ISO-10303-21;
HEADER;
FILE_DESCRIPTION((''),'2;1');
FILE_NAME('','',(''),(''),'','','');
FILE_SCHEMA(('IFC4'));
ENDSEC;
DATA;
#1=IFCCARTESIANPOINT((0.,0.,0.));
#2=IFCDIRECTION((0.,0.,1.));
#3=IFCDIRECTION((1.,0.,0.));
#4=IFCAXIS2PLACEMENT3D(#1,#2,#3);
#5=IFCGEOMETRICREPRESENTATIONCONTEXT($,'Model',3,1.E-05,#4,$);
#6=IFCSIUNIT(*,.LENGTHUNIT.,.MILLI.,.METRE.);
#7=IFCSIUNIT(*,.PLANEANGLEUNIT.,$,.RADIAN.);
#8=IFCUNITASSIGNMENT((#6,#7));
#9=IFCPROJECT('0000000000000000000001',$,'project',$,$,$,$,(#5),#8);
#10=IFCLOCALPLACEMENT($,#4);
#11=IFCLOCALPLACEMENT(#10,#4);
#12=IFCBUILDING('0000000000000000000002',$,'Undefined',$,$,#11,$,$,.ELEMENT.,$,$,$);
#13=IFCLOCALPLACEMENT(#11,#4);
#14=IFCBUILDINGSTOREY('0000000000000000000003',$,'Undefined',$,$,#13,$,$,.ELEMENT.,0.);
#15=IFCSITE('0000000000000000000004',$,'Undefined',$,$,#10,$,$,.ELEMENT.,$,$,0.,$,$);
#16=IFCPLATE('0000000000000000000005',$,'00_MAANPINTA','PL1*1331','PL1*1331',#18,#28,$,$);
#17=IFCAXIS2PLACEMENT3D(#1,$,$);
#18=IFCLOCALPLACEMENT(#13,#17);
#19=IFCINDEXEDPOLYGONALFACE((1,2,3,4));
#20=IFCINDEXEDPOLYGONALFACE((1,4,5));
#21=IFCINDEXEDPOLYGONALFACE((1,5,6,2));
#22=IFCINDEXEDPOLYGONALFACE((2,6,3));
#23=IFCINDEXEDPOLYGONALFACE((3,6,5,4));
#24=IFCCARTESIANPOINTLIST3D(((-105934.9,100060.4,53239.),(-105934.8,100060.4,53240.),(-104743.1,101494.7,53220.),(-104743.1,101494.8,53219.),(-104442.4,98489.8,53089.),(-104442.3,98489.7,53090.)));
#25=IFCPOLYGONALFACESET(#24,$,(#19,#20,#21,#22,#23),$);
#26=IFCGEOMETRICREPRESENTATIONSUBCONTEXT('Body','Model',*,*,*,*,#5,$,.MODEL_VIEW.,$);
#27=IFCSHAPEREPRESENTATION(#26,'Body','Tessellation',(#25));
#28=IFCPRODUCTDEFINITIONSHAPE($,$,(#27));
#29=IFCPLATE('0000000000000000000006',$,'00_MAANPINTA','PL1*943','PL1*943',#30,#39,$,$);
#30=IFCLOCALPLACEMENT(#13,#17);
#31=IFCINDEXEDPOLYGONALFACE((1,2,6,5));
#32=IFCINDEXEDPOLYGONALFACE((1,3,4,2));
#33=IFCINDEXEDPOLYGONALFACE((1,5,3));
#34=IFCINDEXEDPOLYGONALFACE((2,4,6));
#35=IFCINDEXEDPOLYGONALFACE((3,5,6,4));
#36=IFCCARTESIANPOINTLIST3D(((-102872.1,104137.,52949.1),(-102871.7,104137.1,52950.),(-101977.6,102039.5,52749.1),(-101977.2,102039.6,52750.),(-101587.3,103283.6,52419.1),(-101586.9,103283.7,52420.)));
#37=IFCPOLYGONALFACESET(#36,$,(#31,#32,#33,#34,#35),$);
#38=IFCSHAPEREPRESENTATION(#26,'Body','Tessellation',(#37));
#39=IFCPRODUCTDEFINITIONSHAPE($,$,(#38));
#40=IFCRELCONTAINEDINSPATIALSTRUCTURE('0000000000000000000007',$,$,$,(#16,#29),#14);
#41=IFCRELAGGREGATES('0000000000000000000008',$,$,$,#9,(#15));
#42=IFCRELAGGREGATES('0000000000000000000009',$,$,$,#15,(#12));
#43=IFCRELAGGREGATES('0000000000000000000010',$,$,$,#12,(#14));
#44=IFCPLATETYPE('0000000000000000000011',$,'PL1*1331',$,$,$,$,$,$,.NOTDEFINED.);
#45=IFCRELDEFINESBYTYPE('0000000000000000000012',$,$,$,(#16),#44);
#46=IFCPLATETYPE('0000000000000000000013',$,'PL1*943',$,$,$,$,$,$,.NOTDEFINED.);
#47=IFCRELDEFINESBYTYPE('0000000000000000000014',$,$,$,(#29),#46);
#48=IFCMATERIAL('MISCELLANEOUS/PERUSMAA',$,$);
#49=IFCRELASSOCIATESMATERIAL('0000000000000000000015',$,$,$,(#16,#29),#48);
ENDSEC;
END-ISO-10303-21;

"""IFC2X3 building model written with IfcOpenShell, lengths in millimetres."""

from ifc_helpers import new_model, si_unit, frame, origin_with_axes, place, context, subcontext, project, spatial, polyline, outline, extrude, material, type_object, element, save


model = new_model("IFC2X3")

# Units and contexts
model_context = context("Model", 3, precision=1e-05, world=origin_with_axes())
body_context = subcontext(model_context, "Body", "Model", "MODEL_VIEW")
ifc_project = project(units=[si_unit("LENGTHUNIT", "METRE", prefix="MILLI"), si_unit("PLANEANGLEUNIT", "RADIAN")], contexts=[model_context])

# Site, building, storey
site_placement = place(None, origin_with_axes())
site = spatial("IfcSite", under=ifc_project, at=site_placement, Name="Undefined", CompositionType="ELEMENT", RefElevation=0.0)
building_placement = place(site_placement, origin_with_axes())
building = spatial("IfcBuilding", under=site, at=building_placement, Name="Undefined", CompositionType="ELEMENT")
storey_placement = place(building_placement, origin_with_axes())
storey = spatial("IfcBuildingStorey", under=building, at=storey_placement, Name="Undefined", CompositionType="ELEMENT", Elevation=0.0)

# Plates
ifc_material = material(Name="MISCELLANEOUS/PERUSMAA")
plate_type_1 = type_object("IfcPlateType", Name="PL1*1331", PredefinedType="NOTDEFINED")
plate_1_placement = place(storey_placement, frame((-104442.4, 98489.8, 53089.5), z_axis=(-0.061289, 0.037016, -0.997433), x_axis=(-0.687208, 0.72317, 0.069065)))
element("IfcPlate", 1, at=plate_1_placement, inside=storey, type_object=plate_type_1, material=ifc_material, Name="00_MAANPINTA", Description="PL1*1331", ObjectType="PL1*1331", context=body_context, shape_type="SweptSolid", body=[
    extrude(outline(polyline([(0.0, 0.0), (2171.9, 0.0), (2388.8, 1852.3), (0.0, 0.0)])), frame((0.0, 0.0, -0.5), z_axis=(0.0, 0.0, 1.0), x_axis=(1.0, 0.0, 0.0)), (0.0, 0.0, 1.0), 1.0),
])
plate_type_2 = type_object("IfcPlateType", Name="PL1*943", PredefinedType="NOTDEFINED")
plate_2_placement = place(storey_placement, frame((-101977.4, 102039.6, 52749.6), z_axis=(-0.435759, -0.100545, -0.89443), x_axis=(-0.390775, 0.91633, 0.087376)))
element("IfcPlate", 2, at=plate_2_placement, inside=storey, type_object=plate_type_2, material=ifc_material, Name="00_MAANPINTA", Description="PL1*943", ObjectType="PL1*943", context=body_context, shape_type="SweptSolid", body=[
    extrude(outline(polyline([(0.0, 0.0), (2289.0, 0.0), (958.6, 943.4), (0.0, 0.0)])), frame((0.0, 0.0, -0.5), z_axis=(0.0, 0.0, 1.0), x_axis=(1.0, 0.0, 0.0)), (0.0, 0.0, 1.0), 1.0),
])

save(model, "model.ifc")
